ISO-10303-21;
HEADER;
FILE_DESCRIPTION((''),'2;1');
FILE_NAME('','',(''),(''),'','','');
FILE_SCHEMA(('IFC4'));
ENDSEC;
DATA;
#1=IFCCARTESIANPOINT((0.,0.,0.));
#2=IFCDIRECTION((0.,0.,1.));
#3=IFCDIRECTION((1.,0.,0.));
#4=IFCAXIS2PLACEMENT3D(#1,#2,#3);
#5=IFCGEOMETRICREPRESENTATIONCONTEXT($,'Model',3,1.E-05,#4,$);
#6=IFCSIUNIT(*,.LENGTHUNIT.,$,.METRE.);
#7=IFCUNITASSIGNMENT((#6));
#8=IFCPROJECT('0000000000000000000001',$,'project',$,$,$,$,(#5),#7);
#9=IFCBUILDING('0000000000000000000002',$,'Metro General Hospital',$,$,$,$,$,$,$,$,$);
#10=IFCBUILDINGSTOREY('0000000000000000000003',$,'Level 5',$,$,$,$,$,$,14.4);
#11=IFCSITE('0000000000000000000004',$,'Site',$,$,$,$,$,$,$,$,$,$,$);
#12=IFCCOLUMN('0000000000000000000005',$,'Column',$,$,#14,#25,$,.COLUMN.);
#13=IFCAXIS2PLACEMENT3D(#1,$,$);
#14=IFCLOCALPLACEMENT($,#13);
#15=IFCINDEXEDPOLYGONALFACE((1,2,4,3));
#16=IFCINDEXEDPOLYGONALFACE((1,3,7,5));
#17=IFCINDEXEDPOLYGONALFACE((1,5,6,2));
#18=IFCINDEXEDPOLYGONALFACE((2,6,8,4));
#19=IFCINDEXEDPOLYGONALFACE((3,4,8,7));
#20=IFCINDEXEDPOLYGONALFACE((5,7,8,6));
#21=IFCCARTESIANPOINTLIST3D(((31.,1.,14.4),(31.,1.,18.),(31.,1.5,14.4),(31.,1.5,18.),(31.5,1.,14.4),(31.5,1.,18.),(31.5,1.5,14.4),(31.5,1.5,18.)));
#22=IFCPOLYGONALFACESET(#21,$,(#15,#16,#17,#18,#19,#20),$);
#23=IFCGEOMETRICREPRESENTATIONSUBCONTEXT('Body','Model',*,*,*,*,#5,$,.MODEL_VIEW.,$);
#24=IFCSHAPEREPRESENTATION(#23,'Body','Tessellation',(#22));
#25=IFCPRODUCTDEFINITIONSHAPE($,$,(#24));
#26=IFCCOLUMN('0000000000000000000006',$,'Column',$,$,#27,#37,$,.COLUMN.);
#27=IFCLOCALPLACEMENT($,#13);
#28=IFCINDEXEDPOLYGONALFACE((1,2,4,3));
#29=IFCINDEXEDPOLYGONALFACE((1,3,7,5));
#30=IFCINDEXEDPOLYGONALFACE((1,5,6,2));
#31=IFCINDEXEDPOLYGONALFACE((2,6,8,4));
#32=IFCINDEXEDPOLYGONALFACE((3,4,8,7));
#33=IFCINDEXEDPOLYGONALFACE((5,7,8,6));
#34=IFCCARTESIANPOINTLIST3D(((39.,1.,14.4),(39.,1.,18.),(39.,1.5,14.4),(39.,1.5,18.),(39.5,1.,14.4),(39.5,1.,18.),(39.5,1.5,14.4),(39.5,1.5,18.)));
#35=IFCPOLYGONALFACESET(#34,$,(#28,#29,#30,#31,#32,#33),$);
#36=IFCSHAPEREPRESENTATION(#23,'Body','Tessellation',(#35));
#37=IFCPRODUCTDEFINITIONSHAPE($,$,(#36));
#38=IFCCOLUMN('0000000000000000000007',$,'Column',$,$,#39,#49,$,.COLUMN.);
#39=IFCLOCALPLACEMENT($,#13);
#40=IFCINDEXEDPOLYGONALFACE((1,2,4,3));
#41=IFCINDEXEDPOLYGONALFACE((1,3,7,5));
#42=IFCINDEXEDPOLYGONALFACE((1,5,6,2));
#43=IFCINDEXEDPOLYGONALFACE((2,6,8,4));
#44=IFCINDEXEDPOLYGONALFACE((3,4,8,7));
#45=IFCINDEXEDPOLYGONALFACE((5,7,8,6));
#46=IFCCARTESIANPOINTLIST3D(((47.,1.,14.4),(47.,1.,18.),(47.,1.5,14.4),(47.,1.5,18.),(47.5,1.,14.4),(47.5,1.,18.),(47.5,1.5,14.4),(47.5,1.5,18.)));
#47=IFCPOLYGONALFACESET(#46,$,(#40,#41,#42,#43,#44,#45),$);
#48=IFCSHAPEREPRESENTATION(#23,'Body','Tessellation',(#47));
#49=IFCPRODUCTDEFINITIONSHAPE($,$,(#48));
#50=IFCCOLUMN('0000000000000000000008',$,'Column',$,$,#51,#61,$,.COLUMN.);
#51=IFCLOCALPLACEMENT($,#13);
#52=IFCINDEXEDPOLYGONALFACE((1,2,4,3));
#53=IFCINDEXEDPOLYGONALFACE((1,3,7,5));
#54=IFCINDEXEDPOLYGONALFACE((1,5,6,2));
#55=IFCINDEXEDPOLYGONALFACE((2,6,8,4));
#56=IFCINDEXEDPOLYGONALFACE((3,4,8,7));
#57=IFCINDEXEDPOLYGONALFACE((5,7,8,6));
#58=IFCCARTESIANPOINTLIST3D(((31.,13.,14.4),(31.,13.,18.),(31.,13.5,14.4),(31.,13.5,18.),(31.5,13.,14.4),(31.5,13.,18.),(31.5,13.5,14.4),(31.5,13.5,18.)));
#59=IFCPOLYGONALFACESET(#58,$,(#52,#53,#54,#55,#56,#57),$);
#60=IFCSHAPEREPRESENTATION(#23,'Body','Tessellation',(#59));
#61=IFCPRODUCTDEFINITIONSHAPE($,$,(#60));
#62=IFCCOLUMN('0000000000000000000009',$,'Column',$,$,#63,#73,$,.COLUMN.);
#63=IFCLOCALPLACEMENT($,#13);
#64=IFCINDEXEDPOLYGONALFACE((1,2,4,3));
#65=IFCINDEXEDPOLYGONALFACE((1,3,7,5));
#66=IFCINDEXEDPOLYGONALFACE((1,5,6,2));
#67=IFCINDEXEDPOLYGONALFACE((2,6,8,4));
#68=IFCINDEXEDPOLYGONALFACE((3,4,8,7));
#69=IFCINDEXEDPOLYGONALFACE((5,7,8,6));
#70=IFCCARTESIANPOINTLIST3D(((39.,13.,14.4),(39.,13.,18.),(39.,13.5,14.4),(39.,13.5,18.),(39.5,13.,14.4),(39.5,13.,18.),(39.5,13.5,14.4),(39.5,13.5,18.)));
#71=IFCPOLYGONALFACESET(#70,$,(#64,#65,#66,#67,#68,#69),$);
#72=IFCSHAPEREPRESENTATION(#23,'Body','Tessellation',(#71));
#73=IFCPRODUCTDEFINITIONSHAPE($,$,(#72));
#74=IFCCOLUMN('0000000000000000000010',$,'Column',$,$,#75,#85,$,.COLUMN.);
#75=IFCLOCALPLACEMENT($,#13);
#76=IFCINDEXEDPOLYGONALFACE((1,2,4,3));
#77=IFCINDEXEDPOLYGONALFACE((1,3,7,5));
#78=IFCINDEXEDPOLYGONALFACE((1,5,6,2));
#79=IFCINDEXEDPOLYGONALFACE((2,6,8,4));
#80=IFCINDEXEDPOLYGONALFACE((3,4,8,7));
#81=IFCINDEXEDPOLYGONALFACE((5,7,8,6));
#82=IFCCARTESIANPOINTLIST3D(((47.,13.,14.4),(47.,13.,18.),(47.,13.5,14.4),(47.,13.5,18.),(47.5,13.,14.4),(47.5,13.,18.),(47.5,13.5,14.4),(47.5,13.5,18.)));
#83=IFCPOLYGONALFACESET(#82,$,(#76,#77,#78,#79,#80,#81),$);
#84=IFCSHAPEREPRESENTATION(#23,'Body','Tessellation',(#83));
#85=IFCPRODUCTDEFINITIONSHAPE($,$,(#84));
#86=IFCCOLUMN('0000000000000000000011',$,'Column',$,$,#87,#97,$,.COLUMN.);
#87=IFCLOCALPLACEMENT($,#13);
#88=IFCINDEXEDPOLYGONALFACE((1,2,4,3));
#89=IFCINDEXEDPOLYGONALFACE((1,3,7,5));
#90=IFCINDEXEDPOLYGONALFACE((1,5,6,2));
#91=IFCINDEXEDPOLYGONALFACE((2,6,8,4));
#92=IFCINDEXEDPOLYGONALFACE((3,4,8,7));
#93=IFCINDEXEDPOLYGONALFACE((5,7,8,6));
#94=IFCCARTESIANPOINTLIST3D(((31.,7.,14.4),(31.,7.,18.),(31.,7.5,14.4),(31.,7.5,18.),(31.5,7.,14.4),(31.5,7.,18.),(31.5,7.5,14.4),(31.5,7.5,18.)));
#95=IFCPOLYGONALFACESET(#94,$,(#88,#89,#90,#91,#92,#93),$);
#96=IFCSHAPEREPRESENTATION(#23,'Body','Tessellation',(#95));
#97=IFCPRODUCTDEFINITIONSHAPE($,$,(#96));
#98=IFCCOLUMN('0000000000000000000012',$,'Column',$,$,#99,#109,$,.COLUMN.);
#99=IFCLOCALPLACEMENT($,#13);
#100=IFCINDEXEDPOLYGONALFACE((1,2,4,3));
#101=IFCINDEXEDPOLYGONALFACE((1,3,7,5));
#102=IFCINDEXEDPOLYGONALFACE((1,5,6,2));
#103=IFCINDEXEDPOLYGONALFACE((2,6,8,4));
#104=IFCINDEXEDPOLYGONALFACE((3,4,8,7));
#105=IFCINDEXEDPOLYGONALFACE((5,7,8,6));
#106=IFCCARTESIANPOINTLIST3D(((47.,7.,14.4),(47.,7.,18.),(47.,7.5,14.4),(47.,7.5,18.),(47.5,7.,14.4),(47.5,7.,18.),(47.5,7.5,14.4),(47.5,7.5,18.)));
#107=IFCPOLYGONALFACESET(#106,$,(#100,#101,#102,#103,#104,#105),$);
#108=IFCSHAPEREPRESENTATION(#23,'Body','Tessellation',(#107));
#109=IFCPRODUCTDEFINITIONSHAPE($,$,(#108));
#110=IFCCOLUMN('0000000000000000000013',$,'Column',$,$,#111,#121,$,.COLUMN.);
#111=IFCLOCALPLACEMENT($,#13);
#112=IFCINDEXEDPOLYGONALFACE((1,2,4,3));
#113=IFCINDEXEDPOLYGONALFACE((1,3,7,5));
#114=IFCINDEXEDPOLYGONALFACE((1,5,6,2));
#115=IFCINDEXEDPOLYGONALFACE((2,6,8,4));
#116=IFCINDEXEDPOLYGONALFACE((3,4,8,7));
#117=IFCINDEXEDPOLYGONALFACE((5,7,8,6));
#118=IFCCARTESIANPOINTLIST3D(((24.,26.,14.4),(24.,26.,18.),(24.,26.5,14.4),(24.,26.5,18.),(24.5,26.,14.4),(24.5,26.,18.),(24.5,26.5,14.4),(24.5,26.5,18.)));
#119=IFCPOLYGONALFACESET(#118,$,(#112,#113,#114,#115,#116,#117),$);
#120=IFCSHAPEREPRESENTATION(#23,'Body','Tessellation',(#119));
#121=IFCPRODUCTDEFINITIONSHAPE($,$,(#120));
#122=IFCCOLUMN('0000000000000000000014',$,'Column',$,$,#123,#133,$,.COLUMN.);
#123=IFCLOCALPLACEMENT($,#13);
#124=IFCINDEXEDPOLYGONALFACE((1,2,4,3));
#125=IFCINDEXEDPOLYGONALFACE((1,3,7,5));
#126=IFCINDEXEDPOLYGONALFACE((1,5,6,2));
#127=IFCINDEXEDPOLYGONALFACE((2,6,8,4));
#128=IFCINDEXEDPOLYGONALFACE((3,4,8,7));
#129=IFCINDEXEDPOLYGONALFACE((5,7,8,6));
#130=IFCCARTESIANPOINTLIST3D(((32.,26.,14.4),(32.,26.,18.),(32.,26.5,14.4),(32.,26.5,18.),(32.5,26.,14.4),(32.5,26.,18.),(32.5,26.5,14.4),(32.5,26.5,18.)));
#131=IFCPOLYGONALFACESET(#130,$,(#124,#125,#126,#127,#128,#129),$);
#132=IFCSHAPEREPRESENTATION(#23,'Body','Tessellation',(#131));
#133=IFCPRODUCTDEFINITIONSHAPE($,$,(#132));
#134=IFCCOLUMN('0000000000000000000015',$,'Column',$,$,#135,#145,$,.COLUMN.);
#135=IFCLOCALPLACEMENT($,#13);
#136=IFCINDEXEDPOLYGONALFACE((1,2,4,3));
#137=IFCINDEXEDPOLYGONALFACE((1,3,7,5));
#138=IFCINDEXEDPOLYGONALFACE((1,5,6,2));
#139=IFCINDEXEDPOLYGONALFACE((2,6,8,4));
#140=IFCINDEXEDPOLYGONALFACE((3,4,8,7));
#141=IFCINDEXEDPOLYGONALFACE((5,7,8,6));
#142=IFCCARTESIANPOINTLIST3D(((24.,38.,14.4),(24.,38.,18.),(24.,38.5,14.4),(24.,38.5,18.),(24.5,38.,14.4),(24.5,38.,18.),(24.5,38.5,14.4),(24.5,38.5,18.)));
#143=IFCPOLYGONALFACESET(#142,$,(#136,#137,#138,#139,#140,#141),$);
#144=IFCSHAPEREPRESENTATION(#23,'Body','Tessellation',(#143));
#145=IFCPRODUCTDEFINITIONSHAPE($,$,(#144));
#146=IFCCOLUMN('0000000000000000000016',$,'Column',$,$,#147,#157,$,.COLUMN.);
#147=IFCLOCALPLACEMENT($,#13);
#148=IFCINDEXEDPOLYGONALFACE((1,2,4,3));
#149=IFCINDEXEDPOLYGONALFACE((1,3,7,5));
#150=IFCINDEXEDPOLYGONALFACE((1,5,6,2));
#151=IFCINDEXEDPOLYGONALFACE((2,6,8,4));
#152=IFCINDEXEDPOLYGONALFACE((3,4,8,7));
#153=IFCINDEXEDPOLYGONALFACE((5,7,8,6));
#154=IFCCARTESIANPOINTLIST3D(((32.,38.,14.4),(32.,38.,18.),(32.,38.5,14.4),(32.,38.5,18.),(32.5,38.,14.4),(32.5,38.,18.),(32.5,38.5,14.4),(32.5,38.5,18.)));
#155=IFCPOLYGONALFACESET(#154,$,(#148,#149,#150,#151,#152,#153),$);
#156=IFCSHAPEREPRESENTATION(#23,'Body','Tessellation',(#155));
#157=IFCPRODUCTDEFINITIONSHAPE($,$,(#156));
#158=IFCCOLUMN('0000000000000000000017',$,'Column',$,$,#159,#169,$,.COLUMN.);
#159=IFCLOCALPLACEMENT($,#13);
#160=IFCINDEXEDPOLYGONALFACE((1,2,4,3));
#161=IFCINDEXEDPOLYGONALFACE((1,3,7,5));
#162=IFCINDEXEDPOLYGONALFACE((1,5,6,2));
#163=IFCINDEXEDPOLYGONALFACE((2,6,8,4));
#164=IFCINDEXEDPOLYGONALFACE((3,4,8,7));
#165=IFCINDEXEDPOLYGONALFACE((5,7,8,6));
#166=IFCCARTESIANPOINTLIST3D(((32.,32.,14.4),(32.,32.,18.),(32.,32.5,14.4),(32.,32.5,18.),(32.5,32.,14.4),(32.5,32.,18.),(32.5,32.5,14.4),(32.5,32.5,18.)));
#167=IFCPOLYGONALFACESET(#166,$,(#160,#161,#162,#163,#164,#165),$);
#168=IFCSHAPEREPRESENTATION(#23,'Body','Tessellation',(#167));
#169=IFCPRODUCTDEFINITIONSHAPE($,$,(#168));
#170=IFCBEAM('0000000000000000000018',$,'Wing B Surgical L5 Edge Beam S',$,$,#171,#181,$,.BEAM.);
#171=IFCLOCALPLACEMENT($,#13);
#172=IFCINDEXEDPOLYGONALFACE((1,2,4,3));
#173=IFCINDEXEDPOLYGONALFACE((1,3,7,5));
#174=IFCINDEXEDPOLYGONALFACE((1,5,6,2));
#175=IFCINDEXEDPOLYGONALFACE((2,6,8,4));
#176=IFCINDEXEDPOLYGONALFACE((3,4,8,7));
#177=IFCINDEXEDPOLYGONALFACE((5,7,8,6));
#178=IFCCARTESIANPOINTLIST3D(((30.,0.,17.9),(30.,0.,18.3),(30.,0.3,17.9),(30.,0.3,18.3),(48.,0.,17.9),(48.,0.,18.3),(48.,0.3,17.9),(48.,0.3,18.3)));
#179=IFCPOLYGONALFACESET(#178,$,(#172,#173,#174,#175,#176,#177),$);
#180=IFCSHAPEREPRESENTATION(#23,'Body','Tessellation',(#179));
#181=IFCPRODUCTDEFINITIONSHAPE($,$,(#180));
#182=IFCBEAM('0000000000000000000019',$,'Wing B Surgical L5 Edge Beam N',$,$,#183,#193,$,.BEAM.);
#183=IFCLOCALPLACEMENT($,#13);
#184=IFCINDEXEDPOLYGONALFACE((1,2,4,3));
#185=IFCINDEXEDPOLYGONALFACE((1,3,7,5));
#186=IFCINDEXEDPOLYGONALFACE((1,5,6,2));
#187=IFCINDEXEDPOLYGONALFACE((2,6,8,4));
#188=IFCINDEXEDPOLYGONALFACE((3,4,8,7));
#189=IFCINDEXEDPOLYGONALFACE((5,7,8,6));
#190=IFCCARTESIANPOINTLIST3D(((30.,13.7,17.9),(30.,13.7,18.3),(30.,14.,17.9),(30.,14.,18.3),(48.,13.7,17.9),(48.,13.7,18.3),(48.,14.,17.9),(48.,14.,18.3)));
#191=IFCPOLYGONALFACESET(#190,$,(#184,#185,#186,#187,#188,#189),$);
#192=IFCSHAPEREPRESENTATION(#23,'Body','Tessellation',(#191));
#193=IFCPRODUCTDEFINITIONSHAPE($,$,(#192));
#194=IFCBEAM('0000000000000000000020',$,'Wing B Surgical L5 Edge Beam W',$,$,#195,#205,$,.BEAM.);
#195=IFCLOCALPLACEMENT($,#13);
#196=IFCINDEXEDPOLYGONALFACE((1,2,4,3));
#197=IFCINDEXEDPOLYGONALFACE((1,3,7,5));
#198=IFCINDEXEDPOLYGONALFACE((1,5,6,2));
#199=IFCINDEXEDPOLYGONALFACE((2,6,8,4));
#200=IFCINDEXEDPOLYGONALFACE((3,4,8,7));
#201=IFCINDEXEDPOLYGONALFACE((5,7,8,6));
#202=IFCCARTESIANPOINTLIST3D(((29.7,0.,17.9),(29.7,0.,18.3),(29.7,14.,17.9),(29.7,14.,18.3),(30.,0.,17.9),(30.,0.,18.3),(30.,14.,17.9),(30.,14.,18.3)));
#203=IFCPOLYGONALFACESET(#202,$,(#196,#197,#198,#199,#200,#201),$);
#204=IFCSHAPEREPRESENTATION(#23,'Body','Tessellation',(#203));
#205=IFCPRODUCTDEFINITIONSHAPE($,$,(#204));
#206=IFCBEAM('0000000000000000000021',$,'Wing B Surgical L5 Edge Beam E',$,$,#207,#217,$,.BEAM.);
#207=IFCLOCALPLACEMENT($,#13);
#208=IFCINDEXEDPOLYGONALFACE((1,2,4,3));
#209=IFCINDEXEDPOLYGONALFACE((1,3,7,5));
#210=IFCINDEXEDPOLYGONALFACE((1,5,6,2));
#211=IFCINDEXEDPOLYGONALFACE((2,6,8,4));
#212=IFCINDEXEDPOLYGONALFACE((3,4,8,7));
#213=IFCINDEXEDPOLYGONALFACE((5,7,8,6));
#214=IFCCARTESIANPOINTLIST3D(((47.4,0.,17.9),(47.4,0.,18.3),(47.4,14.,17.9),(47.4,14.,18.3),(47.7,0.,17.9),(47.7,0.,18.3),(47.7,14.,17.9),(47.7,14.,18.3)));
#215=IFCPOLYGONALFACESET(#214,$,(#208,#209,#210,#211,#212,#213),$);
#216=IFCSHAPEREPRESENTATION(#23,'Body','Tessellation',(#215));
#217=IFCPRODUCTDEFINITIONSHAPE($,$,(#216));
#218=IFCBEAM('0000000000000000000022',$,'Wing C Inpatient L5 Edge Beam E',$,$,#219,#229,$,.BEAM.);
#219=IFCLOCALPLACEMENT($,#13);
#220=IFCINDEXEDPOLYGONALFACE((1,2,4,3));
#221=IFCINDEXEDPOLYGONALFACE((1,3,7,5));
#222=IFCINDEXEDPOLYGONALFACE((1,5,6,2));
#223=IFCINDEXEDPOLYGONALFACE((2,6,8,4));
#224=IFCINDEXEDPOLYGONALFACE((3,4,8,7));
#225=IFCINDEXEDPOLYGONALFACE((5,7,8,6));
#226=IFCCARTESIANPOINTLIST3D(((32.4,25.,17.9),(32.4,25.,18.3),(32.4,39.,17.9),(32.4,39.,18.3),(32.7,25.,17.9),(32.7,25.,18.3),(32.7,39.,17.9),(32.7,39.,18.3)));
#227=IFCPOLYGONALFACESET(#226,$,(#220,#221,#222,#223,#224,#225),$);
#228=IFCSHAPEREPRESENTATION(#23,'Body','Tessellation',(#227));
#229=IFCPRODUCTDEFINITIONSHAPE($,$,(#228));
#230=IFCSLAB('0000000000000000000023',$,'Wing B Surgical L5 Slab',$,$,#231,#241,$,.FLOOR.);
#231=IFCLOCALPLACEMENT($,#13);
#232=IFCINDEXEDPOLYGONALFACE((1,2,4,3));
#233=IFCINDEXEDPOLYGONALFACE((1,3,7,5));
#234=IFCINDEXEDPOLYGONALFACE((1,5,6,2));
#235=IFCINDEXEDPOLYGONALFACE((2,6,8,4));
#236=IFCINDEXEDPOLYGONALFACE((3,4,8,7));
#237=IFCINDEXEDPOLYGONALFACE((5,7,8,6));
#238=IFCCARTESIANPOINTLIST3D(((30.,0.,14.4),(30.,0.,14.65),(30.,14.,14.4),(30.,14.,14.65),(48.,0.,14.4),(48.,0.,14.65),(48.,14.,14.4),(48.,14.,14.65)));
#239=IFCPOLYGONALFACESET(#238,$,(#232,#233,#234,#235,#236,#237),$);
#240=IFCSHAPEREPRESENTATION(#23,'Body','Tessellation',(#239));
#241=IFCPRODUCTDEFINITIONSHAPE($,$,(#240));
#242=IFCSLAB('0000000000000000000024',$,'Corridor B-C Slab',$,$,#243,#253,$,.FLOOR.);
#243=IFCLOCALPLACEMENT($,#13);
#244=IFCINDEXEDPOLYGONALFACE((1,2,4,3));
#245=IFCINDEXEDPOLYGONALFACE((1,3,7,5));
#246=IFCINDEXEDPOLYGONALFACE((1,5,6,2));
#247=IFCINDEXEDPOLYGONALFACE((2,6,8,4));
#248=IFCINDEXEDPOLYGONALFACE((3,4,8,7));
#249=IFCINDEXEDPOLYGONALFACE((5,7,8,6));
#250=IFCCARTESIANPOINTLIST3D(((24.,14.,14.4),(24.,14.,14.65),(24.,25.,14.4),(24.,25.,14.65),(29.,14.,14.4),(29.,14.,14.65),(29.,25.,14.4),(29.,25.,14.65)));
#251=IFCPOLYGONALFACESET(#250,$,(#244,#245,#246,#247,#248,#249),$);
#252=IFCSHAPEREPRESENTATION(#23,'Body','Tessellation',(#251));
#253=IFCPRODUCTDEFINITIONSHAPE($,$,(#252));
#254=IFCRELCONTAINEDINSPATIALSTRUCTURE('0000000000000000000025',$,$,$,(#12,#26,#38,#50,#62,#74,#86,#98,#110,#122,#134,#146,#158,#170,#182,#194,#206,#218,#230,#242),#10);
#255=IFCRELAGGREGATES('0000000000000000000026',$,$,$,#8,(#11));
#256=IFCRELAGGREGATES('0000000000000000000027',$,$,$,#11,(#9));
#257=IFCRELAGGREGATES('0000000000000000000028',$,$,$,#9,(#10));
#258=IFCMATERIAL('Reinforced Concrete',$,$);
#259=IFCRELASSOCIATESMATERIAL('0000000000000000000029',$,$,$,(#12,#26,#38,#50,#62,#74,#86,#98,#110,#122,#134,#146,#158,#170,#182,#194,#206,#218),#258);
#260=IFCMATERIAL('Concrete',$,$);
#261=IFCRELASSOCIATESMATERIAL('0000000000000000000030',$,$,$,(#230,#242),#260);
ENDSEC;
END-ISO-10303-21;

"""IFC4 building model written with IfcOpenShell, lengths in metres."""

from ifc_helpers import new_model, si_unit, frame, origin_with_axes, place, context, subcontext, project, spatial, line, indexed_curve, outline, extrude, material, element, save


model = new_model("IFC4")

# Units and contexts
model_context = context("Model", 3, precision=1e-05, world=origin_with_axes())
body_context = subcontext(model_context, "Body", "Model", "MODEL_VIEW")
ifc_project = project(units=[si_unit("LENGTHUNIT", "METRE")], contexts=[model_context])

# Site, building, storey
site = spatial("IfcSite", under=ifc_project, Name="Site")
building = spatial("IfcBuilding", under=site, Name="Metro General Hospital")
storey = spatial("IfcBuildingStorey", under=building, Name="Level 5", Elevation=14.4)

# Columns
ifc_material_1 = material(Name="Reinforced Concrete")
for number, where, z_axis, x_axis, name in (
    (1, (31.0, 1.0, 14.4), (0.0, 0.0, 1.0), (1.0, 0.0, 0.0), "Column"),
    (2, (39.0, 1.0, 14.4), (0.0, 0.0, 1.0), (1.0, 0.0, 0.0), "Column"),
    (3, (47.0, 1.0, 14.4), (0.0, 0.0, 1.0), (1.0, 0.0, 0.0), "Column"),
    (4, (31.0, 13.0, 14.4), (0.0, 0.0, 1.0), (1.0, 0.0, 0.0), "Column"),
    (5, (39.0, 13.0, 14.4), (0.0, 0.0, 1.0), (1.0, 0.0, 0.0), "Column"),
    (6, (47.0, 13.0, 14.4), (0.0, 0.0, 1.0), (1.0, 0.0, 0.0), "Column"),
    (7, (31.0, 7.0, 14.4), (0.0, 0.0, 1.0), (1.0, 0.0, 0.0), "Column"),
    (8, (47.0, 7.0, 14.4), (0.0, 0.0, 1.0), (1.0, 0.0, 0.0), "Column"),
    (9, (24.0, 26.0, 14.4), (0.0, 0.0, 1.0), (1.0, 0.0, 0.0), "Column"),
    (10, (32.0, 26.0, 14.4), (0.0, 0.0, 1.0), (1.0, 0.0, 0.0), "Column"),
    (11, (24.0, 38.0, 14.4), (0.0, 0.0, 1.0), (1.0, 0.0, 0.0), "Column"),
    (12, (32.0, 38.0, 14.4), (0.0, 0.0, 1.0), (1.0, 0.0, 0.0), "Column"),
    (13, (32.0, 32.0, 14.4), (0.0, 0.0, 1.0), (1.0, 0.0, 0.0), "Column"),
):
    element("IfcColumn", number, at=place(None, frame(where, z_axis=z_axis, x_axis=x_axis)), inside=storey, material=ifc_material_1, Name=name, PredefinedType="COLUMN", context=body_context, shape_type="SweptSolid", body=[
        extrude(outline(indexed_curve([(0.0, 0.0), (0.5, 0.0), (0.5, 0.5), (0.0, 0.5)], segments=[line(1, 2, 3, 4, 1)])), origin_with_axes(), (0.0, 0.0, 1.0), 3.6),
    ])

# Beams
for number, where, z_axis, x_axis, name in (
    (14, (30.0, 0.0, 17.9), (0.0, 0.0, 1.0), (1.0, 0.0, 0.0), "Wing B Surgical L5 Edge Beam S"),
    (15, (30.0, 13.7, 17.9), (0.0, 0.0, 1.0), (1.0, 0.0, 0.0), "Wing B Surgical L5 Edge Beam N"),
):
    element("IfcBeam", number, at=place(None, frame(where, z_axis=z_axis, x_axis=x_axis)), inside=storey, material=ifc_material_1, Name=name, PredefinedType="BEAM", context=body_context, shape_type="SweptSolid", body=[
        extrude(outline(indexed_curve([(0.0, 0.0), (18.0, 0.0), (18.0, 0.3), (0.0, 0.3)], segments=[line(1, 2, 3, 4, 1)])), origin_with_axes(), (0.0, 0.0, 1.0), 0.4),
    ])
for number, where, z_axis, x_axis, name in (
    (16, (30.0, 0.0, 17.9), (0.0, 0.0, 1.0), (0.0, 1.0, 0.0), "Wing B Surgical L5 Edge Beam W"),
    (17, (47.7, 0.0, 17.9), (0.0, 0.0, 1.0), (0.0, 1.0, 0.0), "Wing B Surgical L5 Edge Beam E"),
    (18, (32.7, 25.0, 17.9), (0.0, 0.0, 1.0), (0.0, 1.0, 0.0), "Wing C Inpatient L5 Edge Beam E"),
):
    element("IfcBeam", number, at=place(None, frame(where, z_axis=z_axis, x_axis=x_axis)), inside=storey, material=ifc_material_1, Name=name, PredefinedType="BEAM", context=body_context, shape_type="SweptSolid", body=[
        extrude(outline(indexed_curve([(0.0, 0.0), (14.0, 0.0), (14.0, 0.3), (0.0, 0.3)], segments=[line(1, 2, 3, 4, 1)])), origin_with_axes(), (0.0, 0.0, 1.0), 0.4),
    ])

# Slabs
ifc_material_2 = material(Name="Concrete")
slab_1_placement = place(None, frame((30.0, 0.0, 14.4), z_axis=(0.0, 0.0, 1.0), x_axis=(1.0, 0.0, 0.0)))
element("IfcSlab", 19, at=slab_1_placement, inside=storey, material=ifc_material_2, Name="Wing B Surgical L5 Slab", PredefinedType="FLOOR", context=body_context, shape_type="SweptSolid", body=[
    extrude(outline(indexed_curve([(0.0, 0.0), (18.0, 0.0), (18.0, 14.0), (0.0, 14.0)], segments=[line(1, 2, 3, 4, 1)])), origin_with_axes(), (0.0, 0.0, 1.0), 0.25),
])
slab_2_placement = place(None, frame((24.0, 14.0, 14.4), z_axis=(0.0, 0.0, 1.0), x_axis=(1.0, 0.0, 0.0)))
element("IfcSlab", 20, at=slab_2_placement, inside=storey, material=ifc_material_2, Name="Corridor B-C Slab", PredefinedType="FLOOR", context=body_context, shape_type="SweptSolid", body=[
    extrude(outline(indexed_curve([(0.0, 0.0), (5.0, 0.0), (5.0, 11.0), (0.0, 11.0)], segments=[line(1, 2, 3, 4, 1)])), origin_with_axes(), (0.0, 0.0, 1.0), 0.25),
])

save(model, "model.ifc")
